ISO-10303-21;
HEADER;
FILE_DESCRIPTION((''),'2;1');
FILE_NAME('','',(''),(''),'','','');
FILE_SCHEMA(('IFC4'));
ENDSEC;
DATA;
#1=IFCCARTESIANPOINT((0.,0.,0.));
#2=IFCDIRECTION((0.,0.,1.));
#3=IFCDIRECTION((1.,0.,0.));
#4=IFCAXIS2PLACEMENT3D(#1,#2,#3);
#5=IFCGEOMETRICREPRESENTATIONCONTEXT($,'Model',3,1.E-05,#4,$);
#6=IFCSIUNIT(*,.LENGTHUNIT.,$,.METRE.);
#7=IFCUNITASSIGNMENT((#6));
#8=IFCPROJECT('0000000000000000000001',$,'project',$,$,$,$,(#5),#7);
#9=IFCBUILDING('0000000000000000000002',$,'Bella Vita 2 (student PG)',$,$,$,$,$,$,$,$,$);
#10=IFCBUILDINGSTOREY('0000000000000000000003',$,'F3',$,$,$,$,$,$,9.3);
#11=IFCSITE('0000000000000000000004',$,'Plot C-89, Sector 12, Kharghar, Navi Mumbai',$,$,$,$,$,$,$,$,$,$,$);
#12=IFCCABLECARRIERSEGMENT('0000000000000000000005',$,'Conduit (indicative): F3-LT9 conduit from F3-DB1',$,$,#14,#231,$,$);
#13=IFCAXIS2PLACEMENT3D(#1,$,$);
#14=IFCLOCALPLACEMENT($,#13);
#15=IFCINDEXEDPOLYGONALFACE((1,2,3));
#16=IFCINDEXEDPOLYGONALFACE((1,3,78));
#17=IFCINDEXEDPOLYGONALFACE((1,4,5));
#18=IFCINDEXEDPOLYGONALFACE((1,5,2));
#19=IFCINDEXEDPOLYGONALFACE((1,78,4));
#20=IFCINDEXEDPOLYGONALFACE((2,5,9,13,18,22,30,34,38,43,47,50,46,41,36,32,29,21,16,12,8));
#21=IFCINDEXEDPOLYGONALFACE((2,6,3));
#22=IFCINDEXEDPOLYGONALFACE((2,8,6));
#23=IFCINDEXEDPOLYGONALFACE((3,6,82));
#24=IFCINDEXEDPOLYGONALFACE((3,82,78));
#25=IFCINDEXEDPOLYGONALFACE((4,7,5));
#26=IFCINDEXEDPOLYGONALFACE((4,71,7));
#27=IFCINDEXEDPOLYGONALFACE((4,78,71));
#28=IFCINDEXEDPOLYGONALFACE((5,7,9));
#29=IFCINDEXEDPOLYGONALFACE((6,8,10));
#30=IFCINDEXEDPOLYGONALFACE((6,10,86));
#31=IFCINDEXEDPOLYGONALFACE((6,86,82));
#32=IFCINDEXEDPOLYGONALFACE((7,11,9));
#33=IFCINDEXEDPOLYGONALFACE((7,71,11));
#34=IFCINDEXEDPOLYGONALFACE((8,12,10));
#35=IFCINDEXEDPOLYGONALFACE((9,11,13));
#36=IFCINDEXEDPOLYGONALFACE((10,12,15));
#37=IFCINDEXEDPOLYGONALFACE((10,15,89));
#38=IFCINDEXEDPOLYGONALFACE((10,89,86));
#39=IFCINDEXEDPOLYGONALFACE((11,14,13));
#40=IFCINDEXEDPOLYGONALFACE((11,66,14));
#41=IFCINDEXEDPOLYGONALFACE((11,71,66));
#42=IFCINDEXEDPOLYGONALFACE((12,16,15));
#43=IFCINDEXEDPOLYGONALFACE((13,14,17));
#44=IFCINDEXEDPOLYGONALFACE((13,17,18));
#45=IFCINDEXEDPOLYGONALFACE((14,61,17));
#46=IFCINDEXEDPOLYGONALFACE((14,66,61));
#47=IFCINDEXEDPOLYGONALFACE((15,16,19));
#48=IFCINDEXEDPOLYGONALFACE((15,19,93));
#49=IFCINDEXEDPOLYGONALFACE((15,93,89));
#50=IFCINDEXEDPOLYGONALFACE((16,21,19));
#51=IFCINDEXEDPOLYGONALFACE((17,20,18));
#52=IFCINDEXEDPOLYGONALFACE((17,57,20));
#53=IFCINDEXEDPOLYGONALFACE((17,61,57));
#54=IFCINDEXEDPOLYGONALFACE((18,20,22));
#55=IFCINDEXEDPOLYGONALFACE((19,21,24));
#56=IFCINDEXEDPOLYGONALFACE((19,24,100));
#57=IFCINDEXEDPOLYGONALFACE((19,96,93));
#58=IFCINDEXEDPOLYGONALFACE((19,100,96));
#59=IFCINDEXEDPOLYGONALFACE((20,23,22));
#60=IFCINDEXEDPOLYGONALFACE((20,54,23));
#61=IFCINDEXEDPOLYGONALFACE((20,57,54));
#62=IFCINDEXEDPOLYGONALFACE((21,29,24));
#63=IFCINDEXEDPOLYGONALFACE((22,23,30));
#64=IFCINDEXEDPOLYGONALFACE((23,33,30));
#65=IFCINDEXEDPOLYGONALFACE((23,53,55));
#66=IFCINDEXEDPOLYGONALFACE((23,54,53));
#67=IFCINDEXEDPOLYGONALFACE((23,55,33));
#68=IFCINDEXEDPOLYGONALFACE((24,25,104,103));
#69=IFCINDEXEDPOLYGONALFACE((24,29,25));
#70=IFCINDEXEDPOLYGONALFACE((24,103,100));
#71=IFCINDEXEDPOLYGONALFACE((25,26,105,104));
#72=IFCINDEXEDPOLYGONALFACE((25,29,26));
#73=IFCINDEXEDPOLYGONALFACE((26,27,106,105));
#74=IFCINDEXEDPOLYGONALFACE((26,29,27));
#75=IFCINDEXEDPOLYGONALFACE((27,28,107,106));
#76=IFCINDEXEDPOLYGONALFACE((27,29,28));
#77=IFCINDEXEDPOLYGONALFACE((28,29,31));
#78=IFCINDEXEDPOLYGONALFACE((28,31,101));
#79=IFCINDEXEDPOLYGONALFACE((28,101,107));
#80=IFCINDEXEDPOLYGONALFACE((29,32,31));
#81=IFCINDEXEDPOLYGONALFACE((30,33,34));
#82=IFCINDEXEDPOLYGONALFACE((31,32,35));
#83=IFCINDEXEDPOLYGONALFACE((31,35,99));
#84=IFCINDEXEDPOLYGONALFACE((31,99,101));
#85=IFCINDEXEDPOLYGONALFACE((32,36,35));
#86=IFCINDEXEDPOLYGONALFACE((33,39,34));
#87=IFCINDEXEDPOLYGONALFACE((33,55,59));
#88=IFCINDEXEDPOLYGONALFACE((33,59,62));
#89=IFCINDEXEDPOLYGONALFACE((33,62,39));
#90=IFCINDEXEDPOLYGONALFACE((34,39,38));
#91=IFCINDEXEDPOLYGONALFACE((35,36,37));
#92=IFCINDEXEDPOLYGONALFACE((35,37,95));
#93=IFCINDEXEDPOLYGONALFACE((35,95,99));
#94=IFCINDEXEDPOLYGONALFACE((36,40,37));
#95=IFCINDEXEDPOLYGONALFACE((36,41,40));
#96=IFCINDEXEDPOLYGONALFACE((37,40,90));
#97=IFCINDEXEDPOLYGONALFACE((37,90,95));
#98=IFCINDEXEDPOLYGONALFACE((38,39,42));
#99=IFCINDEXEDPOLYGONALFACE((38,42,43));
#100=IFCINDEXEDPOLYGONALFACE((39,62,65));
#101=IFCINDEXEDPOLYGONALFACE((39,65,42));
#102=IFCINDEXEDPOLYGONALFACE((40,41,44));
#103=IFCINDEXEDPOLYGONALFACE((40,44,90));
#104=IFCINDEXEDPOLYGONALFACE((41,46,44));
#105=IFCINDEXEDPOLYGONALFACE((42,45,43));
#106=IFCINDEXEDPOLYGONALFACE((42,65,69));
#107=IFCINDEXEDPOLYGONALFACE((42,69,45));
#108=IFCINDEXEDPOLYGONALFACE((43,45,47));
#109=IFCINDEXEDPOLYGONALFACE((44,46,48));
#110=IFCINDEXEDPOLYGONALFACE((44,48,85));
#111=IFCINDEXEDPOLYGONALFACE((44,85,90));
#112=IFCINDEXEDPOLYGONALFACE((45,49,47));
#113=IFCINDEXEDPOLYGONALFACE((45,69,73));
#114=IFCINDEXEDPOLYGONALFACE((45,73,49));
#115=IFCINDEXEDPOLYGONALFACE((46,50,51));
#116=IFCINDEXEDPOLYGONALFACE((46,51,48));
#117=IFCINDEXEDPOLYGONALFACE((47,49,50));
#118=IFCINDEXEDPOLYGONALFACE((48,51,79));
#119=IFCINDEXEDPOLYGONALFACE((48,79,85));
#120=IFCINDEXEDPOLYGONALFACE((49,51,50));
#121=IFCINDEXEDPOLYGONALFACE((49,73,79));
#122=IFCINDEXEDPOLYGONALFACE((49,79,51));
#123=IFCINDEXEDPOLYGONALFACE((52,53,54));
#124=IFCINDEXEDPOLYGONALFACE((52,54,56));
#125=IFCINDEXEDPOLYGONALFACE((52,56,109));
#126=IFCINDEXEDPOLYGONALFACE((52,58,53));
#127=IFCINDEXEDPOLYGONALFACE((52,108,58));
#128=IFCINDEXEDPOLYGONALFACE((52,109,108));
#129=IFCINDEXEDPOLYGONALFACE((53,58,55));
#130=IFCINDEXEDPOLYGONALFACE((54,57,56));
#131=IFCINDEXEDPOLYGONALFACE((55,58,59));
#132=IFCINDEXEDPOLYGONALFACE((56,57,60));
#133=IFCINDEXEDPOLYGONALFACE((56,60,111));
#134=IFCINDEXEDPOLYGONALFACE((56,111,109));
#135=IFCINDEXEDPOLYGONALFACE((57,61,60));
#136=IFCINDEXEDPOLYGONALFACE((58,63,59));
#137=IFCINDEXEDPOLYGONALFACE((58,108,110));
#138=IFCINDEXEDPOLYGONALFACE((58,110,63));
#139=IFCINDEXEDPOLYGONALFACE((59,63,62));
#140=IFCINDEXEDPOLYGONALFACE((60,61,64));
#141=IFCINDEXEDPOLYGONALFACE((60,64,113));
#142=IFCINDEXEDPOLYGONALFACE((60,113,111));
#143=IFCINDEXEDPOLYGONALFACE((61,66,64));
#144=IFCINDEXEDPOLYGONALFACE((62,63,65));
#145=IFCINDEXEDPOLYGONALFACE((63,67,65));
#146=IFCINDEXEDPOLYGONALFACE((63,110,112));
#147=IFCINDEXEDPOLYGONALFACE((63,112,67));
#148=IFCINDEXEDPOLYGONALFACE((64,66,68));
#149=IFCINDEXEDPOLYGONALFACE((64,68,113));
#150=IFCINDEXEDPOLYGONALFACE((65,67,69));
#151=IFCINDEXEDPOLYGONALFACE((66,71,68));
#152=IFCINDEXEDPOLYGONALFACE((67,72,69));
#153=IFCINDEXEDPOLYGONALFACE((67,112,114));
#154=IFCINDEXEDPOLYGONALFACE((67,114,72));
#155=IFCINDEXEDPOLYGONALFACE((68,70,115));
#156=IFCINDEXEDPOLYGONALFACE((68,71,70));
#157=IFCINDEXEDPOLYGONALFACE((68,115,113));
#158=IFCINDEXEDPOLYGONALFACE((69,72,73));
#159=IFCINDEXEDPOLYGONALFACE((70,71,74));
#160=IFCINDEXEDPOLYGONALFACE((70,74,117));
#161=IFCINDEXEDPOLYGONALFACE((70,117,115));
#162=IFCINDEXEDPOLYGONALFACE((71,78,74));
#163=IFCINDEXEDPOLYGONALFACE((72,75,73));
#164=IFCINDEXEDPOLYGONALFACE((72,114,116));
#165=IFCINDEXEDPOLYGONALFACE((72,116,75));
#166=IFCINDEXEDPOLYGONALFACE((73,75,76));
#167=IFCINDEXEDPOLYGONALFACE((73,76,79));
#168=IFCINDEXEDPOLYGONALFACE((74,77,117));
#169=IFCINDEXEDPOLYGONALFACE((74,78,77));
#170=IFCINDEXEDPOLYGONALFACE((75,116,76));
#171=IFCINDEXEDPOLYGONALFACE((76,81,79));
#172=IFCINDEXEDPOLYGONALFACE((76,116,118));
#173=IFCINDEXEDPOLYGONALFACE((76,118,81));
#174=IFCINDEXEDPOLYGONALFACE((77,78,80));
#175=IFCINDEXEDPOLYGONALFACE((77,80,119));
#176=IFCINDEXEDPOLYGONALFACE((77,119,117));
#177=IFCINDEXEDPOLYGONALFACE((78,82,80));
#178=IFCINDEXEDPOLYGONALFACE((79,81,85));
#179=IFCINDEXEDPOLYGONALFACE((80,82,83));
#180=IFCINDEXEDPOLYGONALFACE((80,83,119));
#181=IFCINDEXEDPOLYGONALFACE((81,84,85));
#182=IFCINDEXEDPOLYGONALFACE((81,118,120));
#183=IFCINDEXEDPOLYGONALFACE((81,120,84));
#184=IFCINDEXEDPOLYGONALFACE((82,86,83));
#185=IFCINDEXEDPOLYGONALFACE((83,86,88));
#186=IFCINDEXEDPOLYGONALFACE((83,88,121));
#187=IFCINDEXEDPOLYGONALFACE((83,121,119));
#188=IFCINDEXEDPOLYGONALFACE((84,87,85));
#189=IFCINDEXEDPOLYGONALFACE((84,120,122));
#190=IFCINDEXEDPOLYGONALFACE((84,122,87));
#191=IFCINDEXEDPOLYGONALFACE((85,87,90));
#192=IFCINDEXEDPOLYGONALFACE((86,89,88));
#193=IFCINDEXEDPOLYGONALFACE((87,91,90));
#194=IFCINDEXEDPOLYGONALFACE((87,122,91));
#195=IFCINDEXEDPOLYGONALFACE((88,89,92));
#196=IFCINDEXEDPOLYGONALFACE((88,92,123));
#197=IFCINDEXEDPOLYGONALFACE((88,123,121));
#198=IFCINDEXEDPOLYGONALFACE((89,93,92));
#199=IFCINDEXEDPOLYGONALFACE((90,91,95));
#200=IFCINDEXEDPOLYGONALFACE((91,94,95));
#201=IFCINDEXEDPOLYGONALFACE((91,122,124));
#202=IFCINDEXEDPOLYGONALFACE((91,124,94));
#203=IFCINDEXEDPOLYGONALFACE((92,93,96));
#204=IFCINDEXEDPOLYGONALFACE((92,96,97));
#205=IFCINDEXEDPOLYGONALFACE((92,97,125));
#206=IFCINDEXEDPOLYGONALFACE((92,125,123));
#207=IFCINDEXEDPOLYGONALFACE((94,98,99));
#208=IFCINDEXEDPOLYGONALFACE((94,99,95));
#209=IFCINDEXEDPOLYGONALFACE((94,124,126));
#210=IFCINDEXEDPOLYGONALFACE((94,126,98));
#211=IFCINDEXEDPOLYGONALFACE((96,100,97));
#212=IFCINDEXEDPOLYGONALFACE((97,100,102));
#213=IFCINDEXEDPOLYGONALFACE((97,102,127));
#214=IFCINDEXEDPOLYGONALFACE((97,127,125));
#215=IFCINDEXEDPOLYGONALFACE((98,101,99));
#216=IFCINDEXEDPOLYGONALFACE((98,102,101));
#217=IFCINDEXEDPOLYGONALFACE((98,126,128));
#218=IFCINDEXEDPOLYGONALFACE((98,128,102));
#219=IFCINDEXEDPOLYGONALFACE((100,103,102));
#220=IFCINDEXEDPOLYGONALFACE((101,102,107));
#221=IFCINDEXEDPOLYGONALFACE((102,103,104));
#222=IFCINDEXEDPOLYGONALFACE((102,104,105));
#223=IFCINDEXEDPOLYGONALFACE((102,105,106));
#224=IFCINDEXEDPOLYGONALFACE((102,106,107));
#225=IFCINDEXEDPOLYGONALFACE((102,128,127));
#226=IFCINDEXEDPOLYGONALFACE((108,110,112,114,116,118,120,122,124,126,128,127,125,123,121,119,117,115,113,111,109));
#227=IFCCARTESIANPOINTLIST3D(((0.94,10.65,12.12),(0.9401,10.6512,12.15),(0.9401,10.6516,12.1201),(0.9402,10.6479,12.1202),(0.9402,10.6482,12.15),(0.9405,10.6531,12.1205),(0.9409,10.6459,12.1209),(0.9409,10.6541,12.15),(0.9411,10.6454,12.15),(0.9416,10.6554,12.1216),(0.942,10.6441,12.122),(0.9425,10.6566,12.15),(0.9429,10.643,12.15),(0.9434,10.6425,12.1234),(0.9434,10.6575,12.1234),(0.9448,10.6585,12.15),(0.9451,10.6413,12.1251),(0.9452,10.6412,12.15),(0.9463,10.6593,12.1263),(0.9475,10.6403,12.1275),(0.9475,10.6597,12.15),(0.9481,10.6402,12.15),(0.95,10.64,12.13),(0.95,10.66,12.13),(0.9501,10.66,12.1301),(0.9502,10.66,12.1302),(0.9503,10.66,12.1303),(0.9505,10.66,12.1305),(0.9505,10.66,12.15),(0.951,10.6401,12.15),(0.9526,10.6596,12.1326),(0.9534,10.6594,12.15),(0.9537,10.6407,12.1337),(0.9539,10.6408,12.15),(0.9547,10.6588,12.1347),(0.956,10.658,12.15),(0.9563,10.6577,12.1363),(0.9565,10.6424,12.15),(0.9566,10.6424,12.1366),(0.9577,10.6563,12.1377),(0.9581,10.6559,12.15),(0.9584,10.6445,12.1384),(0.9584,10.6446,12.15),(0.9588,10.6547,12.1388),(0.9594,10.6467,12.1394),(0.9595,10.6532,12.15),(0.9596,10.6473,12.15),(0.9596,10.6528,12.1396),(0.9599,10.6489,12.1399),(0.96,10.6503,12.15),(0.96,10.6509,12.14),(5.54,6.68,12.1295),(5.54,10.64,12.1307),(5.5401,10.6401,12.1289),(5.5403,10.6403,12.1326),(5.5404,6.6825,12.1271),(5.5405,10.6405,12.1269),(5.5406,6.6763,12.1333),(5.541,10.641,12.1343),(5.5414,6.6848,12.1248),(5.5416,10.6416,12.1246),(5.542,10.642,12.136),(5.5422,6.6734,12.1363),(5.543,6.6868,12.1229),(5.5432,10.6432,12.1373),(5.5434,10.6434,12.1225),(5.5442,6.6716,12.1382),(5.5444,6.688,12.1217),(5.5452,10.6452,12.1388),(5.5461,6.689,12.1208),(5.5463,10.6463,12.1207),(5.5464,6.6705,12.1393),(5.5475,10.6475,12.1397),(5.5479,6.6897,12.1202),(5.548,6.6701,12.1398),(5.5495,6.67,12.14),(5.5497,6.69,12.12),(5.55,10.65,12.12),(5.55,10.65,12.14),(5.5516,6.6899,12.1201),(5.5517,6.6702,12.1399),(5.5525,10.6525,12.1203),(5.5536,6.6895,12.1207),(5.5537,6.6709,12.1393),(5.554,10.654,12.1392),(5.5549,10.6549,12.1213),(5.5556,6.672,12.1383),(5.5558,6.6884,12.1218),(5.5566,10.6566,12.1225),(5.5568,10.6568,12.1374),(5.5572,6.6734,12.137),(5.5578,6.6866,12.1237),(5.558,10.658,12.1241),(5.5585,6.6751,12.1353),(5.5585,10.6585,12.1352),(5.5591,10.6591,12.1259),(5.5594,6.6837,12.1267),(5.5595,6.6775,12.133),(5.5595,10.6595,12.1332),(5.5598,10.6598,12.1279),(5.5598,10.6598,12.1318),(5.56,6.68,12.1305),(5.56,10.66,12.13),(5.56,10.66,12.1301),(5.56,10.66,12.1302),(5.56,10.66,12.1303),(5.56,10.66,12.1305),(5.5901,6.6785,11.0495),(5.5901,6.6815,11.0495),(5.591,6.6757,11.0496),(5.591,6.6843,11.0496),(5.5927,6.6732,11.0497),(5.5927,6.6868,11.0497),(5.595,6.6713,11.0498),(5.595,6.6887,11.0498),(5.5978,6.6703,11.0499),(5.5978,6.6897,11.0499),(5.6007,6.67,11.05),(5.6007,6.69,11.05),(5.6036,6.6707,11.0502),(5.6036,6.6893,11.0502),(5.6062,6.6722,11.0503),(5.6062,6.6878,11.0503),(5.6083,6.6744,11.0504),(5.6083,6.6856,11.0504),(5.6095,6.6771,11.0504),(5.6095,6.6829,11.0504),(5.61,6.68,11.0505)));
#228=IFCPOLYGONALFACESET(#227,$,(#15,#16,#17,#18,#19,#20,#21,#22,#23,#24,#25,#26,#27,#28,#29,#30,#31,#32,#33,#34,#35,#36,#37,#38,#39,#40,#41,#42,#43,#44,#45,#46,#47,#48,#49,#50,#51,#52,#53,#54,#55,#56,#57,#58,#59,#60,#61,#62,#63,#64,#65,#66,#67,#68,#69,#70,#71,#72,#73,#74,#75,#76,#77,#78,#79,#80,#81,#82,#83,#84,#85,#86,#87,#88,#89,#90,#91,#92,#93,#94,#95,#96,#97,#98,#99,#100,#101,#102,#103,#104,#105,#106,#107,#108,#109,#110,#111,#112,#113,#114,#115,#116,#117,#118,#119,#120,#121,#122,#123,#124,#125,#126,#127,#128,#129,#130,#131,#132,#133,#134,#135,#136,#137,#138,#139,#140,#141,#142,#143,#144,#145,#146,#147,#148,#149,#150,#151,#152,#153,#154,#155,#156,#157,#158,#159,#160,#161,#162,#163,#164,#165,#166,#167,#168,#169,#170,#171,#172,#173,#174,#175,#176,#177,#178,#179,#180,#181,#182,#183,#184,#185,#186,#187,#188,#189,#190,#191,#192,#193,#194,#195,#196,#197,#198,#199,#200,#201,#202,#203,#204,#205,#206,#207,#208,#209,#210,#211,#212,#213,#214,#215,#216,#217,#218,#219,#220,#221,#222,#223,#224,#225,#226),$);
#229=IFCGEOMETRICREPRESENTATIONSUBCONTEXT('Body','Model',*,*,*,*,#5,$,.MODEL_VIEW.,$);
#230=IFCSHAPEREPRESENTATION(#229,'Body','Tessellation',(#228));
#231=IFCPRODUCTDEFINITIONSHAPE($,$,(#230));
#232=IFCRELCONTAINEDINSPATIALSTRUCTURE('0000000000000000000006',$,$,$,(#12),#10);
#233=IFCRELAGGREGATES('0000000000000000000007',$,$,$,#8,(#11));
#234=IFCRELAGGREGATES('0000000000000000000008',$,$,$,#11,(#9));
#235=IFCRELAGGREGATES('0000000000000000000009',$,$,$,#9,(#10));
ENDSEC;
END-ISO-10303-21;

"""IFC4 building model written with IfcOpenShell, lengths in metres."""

from ifc_helpers import new_model, entity, si_unit, origin, origin_with_axes, place, context, subcontext, project, spatial, element, save


model = new_model("IFC4")

# Units and contexts
model_context = context("Model", 3, precision=1e-05, world=origin_with_axes())
body_context = subcontext(model_context, "Body", "Model", "MODEL_VIEW")
ifc_project = project(units=[si_unit("LENGTHUNIT", "METRE")], contexts=[model_context])

# Site, building, storey
site = spatial("IfcSite", under=ifc_project, Name="Plot C-89, Sector 12, Kharghar, Navi Mumbai")
building = spatial("IfcBuilding", under=site, Name="Bella Vita 2 (student PG)")
storey = spatial("IfcBuildingStorey", under=building, Name="F3", Elevation=9.3)

# Cable carrier segment
cable_carrier_segment_1_placement = place(None, origin())
element("IfcCableCarrierSegment", 1, at=cable_carrier_segment_1_placement, inside=storey, Name="Conduit (indicative): F3-LT9 conduit from F3-DB1", context=body_context, shape_type="AdvancedSweptSolid", body=[
    entity("IfcSweptDiskSolid", entity("IfcPolyline", [entity("IfcCartesianPoint", [5.6, 6.68, 11.05]), entity("IfcCartesianPoint", [5.55, 6.68, 12.13]), entity("IfcCartesianPoint", [5.55, 10.65, 12.13]), entity("IfcCartesianPoint", [0.95, 10.65, 12.13]), entity("IfcCartesianPoint", [0.95, 10.65, 12.15])]), 0.01),
])

save(model, "model.ifc")
